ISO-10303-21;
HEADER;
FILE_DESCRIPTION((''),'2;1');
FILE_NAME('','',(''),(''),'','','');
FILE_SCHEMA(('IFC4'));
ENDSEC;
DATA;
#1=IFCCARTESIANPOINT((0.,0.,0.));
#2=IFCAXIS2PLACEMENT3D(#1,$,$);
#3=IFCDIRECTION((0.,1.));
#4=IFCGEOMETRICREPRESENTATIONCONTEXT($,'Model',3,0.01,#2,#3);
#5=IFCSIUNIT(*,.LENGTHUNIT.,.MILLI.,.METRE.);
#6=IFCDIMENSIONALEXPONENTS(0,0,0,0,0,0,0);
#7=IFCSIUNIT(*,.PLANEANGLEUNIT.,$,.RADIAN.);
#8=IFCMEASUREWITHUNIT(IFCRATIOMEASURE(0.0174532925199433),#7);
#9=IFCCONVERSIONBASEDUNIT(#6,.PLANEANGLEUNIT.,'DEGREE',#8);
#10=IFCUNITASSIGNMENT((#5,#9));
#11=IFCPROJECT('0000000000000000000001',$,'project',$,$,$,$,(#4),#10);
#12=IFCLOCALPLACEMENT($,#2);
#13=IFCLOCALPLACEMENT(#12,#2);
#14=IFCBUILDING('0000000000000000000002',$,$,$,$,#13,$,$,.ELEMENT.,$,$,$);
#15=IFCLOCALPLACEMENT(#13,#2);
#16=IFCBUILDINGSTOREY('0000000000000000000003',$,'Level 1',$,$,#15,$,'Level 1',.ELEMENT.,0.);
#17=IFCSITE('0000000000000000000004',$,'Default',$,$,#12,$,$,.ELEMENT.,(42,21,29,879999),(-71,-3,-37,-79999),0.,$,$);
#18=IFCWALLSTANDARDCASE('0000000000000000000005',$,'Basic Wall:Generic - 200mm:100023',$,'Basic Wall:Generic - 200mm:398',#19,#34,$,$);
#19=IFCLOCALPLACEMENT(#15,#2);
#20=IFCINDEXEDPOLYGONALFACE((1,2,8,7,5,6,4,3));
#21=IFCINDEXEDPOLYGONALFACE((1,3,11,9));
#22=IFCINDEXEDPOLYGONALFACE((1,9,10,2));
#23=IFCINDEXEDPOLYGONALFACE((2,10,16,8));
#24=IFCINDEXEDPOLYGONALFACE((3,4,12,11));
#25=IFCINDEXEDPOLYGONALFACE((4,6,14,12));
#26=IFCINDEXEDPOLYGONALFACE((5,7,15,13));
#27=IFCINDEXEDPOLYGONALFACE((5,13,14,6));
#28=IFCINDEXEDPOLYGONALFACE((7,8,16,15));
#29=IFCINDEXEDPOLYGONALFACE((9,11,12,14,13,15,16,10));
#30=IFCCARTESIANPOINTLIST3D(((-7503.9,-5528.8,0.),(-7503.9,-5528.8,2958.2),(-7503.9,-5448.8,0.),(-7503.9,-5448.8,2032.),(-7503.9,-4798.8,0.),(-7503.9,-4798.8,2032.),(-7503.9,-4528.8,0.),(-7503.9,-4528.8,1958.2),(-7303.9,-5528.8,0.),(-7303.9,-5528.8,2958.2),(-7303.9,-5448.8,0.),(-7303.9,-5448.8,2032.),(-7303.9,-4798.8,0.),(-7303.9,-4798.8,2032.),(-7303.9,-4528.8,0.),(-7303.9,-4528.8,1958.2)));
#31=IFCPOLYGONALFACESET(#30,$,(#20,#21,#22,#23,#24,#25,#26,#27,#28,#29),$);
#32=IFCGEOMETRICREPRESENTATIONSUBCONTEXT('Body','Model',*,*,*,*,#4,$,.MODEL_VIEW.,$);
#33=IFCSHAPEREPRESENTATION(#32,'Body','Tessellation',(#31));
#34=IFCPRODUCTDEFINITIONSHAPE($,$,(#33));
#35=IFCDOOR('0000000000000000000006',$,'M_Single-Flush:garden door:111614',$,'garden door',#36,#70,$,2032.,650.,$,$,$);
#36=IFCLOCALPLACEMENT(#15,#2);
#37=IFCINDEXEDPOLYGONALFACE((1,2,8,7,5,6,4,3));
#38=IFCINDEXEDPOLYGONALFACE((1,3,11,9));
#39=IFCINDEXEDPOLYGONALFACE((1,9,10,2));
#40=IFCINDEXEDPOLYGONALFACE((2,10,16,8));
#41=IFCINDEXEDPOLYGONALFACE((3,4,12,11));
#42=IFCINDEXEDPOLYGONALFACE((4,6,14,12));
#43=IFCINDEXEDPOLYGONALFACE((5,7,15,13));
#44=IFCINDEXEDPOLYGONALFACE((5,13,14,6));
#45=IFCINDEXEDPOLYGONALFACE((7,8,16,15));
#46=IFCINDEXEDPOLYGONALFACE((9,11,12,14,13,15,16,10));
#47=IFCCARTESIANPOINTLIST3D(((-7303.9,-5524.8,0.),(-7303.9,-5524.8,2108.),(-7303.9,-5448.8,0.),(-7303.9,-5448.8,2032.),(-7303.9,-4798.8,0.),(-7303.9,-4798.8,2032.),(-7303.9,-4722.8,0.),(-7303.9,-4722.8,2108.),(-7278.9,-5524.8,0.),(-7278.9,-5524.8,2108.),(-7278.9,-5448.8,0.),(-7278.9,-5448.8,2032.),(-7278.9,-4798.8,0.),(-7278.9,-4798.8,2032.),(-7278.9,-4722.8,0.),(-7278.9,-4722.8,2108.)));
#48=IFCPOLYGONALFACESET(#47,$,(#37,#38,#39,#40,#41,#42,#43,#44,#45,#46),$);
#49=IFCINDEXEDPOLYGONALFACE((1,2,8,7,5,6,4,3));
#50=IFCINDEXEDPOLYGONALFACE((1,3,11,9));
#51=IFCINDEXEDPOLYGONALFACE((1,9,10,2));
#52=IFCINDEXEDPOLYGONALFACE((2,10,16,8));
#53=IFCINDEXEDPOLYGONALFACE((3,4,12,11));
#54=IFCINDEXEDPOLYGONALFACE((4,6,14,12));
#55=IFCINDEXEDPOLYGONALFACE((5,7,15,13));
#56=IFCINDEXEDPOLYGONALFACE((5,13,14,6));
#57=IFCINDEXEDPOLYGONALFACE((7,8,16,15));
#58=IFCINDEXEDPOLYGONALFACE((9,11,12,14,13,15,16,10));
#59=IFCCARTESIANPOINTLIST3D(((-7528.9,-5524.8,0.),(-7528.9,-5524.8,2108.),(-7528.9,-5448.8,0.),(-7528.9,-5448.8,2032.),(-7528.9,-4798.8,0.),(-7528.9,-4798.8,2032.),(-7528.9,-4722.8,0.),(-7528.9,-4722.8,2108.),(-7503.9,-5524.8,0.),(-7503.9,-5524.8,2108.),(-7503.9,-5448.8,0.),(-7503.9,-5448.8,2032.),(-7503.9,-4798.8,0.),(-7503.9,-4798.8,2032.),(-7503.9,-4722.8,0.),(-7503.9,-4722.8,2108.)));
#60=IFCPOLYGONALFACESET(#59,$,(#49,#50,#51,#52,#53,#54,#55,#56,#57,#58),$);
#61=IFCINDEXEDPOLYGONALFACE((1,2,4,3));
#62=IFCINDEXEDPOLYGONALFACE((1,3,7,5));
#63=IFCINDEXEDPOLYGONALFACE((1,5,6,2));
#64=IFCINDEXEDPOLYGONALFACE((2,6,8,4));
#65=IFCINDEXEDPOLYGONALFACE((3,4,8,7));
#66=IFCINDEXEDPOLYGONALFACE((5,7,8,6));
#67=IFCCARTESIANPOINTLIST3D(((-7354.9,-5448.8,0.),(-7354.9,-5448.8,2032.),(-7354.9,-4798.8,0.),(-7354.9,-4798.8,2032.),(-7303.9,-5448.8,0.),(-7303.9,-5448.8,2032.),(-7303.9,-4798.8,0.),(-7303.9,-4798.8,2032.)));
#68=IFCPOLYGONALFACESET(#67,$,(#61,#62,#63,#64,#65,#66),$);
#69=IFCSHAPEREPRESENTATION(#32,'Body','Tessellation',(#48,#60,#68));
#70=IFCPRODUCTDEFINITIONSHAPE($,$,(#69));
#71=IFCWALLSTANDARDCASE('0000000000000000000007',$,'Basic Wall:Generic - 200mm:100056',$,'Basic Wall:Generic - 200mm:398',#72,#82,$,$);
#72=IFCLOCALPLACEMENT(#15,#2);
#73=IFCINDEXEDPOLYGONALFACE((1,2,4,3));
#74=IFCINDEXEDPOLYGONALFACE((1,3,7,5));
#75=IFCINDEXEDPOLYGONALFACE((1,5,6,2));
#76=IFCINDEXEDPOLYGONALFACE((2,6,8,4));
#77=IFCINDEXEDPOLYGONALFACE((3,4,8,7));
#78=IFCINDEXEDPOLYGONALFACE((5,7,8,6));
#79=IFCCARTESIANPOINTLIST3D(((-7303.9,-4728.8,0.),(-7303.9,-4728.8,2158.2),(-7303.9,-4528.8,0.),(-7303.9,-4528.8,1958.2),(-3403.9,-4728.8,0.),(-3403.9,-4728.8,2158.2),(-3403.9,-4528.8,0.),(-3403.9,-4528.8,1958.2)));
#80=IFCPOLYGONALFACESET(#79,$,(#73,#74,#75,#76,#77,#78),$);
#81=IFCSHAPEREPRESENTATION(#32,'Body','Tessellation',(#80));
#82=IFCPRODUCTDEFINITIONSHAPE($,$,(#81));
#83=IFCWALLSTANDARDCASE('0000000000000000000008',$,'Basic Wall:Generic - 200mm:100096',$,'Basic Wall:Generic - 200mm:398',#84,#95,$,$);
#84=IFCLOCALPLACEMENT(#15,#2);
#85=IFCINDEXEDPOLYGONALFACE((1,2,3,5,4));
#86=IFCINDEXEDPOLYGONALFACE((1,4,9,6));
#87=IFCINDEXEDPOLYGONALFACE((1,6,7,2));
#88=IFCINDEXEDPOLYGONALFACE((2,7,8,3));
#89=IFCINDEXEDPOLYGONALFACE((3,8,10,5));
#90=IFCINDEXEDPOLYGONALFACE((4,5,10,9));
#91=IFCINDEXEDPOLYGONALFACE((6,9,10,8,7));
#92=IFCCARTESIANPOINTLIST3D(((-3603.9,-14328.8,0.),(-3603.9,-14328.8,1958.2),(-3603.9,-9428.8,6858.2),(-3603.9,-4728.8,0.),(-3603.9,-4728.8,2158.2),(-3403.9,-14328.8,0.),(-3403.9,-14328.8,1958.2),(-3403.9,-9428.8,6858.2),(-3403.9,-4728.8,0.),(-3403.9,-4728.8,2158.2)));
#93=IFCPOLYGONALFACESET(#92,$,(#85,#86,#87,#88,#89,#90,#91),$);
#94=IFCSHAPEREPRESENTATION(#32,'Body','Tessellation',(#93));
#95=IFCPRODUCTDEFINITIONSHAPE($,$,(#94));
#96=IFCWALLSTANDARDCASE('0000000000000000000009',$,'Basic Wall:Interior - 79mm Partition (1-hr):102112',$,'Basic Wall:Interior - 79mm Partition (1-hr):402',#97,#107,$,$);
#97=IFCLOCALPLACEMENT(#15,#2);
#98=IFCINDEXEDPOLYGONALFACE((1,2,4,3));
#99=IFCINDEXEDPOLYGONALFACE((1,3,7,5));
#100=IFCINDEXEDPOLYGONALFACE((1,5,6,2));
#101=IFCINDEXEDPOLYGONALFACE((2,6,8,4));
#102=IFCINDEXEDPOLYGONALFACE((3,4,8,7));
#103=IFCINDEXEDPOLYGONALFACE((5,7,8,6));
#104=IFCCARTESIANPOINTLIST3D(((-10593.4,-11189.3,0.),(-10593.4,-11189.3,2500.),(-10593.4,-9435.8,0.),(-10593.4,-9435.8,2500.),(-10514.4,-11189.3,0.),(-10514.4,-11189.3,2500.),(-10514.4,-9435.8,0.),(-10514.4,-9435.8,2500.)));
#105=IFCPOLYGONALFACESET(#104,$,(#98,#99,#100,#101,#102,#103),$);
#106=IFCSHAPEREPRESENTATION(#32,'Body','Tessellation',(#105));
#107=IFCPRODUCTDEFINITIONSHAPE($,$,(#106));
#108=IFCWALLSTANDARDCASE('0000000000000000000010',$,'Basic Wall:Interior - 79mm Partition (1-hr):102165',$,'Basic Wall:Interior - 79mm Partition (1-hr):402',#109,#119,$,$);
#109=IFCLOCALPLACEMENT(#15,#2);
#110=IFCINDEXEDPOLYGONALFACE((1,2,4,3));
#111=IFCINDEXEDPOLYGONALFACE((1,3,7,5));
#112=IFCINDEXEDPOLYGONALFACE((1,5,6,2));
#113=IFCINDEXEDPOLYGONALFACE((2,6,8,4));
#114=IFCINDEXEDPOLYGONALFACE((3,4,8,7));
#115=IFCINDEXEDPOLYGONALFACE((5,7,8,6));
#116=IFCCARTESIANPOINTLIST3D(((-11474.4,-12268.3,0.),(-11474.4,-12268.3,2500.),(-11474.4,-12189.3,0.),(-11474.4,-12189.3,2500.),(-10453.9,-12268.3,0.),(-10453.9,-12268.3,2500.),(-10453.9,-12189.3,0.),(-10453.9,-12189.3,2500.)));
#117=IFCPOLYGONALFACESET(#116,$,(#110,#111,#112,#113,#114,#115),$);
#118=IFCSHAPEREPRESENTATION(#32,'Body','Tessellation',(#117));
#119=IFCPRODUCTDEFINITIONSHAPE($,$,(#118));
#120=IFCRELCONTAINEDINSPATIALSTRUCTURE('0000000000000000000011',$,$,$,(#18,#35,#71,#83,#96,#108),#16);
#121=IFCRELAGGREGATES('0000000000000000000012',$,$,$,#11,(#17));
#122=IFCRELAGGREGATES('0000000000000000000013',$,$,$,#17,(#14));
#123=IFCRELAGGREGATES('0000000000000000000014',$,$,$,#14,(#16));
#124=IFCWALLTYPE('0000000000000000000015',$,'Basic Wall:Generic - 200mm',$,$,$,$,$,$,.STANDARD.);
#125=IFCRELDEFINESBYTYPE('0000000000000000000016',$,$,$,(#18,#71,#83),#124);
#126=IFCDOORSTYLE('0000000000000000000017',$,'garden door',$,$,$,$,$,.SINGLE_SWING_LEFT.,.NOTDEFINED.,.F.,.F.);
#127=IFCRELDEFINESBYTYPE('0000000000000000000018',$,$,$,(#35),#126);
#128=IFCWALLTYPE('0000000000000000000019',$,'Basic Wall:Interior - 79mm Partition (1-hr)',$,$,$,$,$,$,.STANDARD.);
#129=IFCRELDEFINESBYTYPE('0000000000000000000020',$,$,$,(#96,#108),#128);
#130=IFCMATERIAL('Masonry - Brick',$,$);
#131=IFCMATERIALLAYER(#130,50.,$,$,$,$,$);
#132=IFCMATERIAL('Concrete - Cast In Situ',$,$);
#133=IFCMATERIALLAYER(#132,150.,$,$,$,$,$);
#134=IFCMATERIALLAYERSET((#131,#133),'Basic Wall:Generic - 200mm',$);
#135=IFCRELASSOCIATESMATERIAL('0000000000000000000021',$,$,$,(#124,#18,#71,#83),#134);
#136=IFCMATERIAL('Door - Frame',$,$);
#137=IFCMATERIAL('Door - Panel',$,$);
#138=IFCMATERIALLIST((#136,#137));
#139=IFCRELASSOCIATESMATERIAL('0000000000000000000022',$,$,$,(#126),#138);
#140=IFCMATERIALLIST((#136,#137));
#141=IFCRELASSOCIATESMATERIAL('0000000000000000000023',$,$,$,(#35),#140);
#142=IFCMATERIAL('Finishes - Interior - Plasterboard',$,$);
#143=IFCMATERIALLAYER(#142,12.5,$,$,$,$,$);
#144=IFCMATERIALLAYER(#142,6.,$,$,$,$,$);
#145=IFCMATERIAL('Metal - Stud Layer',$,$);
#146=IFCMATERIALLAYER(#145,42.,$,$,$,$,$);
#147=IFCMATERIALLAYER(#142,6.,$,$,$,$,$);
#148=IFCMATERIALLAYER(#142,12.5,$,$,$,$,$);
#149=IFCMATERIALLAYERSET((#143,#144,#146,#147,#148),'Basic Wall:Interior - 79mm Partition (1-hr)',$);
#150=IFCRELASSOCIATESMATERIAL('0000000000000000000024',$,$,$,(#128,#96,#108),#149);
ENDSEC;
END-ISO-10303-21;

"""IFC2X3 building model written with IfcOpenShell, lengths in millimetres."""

from ifc_helpers import new_model, entity, si_unit, converted_unit, direction, frame, frame_2d, origin, place, context, subcontext, project, spatial, polyline, rectangle, outline, extrude, clip, bounded_halfspace, source, transform, mapped, material, material_list, layer, layer_set, layer_usage, type_object, type_shapes, element, fill, save


model = new_model("IFC2X3")

# Units and contexts
model_context = context("Model", 3, precision=0.01, world=origin(), true_north=direction((0.0, 1.0)))
body_context = subcontext(model_context, "Body", "Model", "MODEL_VIEW")
ifc_project = project(units=[si_unit("LENGTHUNIT", "METRE", prefix="MILLI"), converted_unit("PLANEANGLEUNIT", "DEGREE", entity("IfcRatioMeasure", 0.0174532925199433), si_unit("PLANEANGLEUNIT", "RADIAN"), dimensions=[0, 0, 0, 0, 0, 0, 0])], contexts=[model_context])

# Site, building, storey
site_placement = place(None, origin())
site = spatial("IfcSite", under=ifc_project, at=site_placement, Name="Default", CompositionType="ELEMENT", RefLatitude=(42, 21, 29, 879999), RefLongitude=(-71, -3, -37, -79999), RefElevation=0.0)
building_placement = place(site_placement, origin())
building = spatial("IfcBuilding", under=site, at=building_placement, CompositionType="ELEMENT")
storey_placement = place(building_placement, origin())
storey = spatial("IfcBuildingStorey", under=building, at=storey_placement, Name="Level 1", LongName="Level 1", CompositionType="ELEMENT", Elevation=0.0)

# Wall, opening, door
ifc_material_1 = material(Name="Masonry - Brick")
ifc_layer_1 = layer(ifc_material_1, 50.0)
ifc_material_2 = material(Name="Concrete - Cast In Situ")
ifc_layer_2 = layer(ifc_material_2, 150.0)
ifc_layer_set_1 = layer_set([ifc_layer_1, ifc_layer_2], Name="Basic Wall:Generic - 200mm")
ifc_layer_usage_1 = layer_usage(ifc_layer_set_1, "AXIS2", "NEGATIVE", 100.0)
wall_type_1 = type_object("IfcWallType", Name="Basic Wall:Generic - 200mm", PredefinedType="STANDARD", material=ifc_layer_set_1)
wall_1_placement = place(storey_placement, frame((-7403.9, -5528.8, 0.0), z_axis=(0.0, 0.0, 1.0), x_axis=(0.0, 1.0, 0.0)))
wall_1 = element("IfcWallStandardCase", 1, at=wall_1_placement, inside=storey, type_object=wall_type_1, material=ifc_layer_usage_1, Name="Basic Wall:Generic - 200mm:100023", ObjectType="Basic Wall:Generic - 200mm:398", context=body_context, shape_type="Clipping", body=[
    clip(extrude(rectangle(XDim=1000.0, YDim=200.0, at=frame_2d((500.0, 0.0), x_axis=(-1.0, 0.0))), origin(), (0.0, 0.0, 1.0), 2958.2), bounded_halfspace(frame((0.0, 100.0, 2958.2), z_axis=(-0.707107, 0.0, -0.707107), x_axis=(0.0, 1.0, 0.0)), True, frame((0.0, 100.0, 2958.2)), polyline([(0.0, 0.0), (0.0, -200.0), (800.0, -200.0), (1000.0, -200.0), (1000.0, 0.0), (400.0, 0.0), (0.0, 0.0)]))),
])
opening_1_placement = place(wall_1_placement, frame((730.0, 100.0, 0.0)))
opening_1 = element("IfcOpeningElement", 2, at=opening_1_placement, cuts=wall_1, ObjectType="Opening", context=body_context, shape_type="SweptSolid", body=[
    extrude(rectangle(XDim=650.0, YDim=2032.0, at=frame_2d((1016.0, 325.0), x_axis=(0.0, -1.0))), frame((0.0, 0.0, 0.0), z_axis=(0.0, -1.0, 0.0), x_axis=(0.0, 0.0, 1.0)), (0.0, 0.0, 1.0), 200.0),
])
ifc_material_3 = material(Name="Door - Frame")
ifc_material_4 = material(Name="Door - Panel")
ifc_material_list_1 = material_list([ifc_material_3, ifc_material_4])
ifc_material_list_2 = material_list([ifc_material_3, ifc_material_4])
door_style_1 = type_object("IfcDoorStyle", Name="garden door", ConstructionType="NOTDEFINED", OperationType="SINGLE_SWING_LEFT", ParameterTakesPrecedence=False, Sizeable=False, material=ifc_material_list_2)
shared_shape_1 = source(origin(), body_context, "Body", "SweptSolid", [
    extrude(outline(polyline([(-401.0, -1073.0), (401.0, -1073.0), (401.0, 1035.0), (325.0, 1035.0), (325.0, -997.0), (-325.0, -997.0), (-325.0, 1035.0), (-401.0, 1035.0), (-401.0, -1073.0)])), frame((325.0, 225.0, 1035.0), z_axis=(0.0, -1.0, 0.0), x_axis=(-1.0, 0.0, 0.0)), (0.0, 0.0, 1.0), 25.0),
    extrude(outline(polyline([(-1073.0, -401.0), (1035.0, -401.0), (1035.0, -325.0), (-997.0, -325.0), (-997.0, 325.0), (1035.0, 325.0), (1035.0, 401.0), (-1073.0, 401.0), (-1073.0, -401.0)])), frame((325.0, 0.0, 1035.0), z_axis=(0.0, -1.0, 0.0), x_axis=(0.0, 0.0, -1.0)), (0.0, 0.0, 1.0), 25.0),
    extrude(rectangle(XDim=650.0, YDim=51.0, at=frame_2d((0.0, 0.0), x_axis=(1.0, 0.0))), frame((325.0, 174.5, 0.0)), (0.0, 0.0, 1.0), 2032.0),
])
type_shapes(door_style_1, [shared_shape_1])
door_1_placement = place(opening_1_placement, frame((0.0, 0.0, 0.0), z_axis=(0.0, 0.0, 1.0), x_axis=(-1.0, 0.0, 0.0)))
door_1 = element("IfcDoor", 3, at=door_1_placement, inside=storey, type_object=door_style_1, material=ifc_material_list_1, Name="M_Single-Flush:garden door:111614", ObjectType="garden door", OverallHeight=2032.0, OverallWidth=650.0, context=body_context, shape_type="MappedRepresentation", body=[
    mapped(shared_shape_1, transform((0.0, 0.0, 0.0), scale=1.0)),
])
fill(opening_1, door_1)

# Walls
ifc_layer_usage_2 = layer_usage(ifc_layer_set_1, "AXIS2", "NEGATIVE", 100.0)
wall_2_placement = place(storey_placement, frame((-7303.9, -4628.8, 0.0)))
element("IfcWallStandardCase", 4, at=wall_2_placement, inside=storey, type_object=wall_type_1, material=ifc_layer_usage_2, Name="Basic Wall:Generic - 200mm:100056", ObjectType="Basic Wall:Generic - 200mm:398", context=body_context, shape_type="Clipping", body=[
    clip(extrude(rectangle(XDim=3900.0, YDim=200.0, at=frame_2d((1950.0, 0.0), x_axis=(-1.0, 0.0))), origin(), (0.0, 0.0, 1.0), 2158.2), bounded_halfspace(frame((0.0, -100.0, 2158.2), z_axis=(0.0, -0.707107, -0.707107), x_axis=(-1.0, 0.0, 0.0)), True, frame((0.0, -100.0, 2158.2)), polyline([(0.0, 0.0), (3700.0, 0.0), (3900.0, 0.0), (3900.0, 200.0), (0.0, 200.0), (0.0, 0.0)]))),
])
ifc_layer_usage_3 = layer_usage(ifc_layer_set_1, "AXIS2", "NEGATIVE", 100.0)
wall_3_placement = place(storey_placement, frame((-3503.9, -4728.8, 0.0), z_axis=(0.0, 0.0, 1.0), x_axis=(0.0, -1.0, 0.0)))
element("IfcWallStandardCase", 5, at=wall_3_placement, inside=storey, type_object=wall_type_1, material=ifc_layer_usage_3, Name="Basic Wall:Generic - 200mm:100096", ObjectType="Basic Wall:Generic - 200mm:398", context=body_context, shape_type="Clipping", body=[
    clip(clip(extrude(rectangle(XDim=9600.0, YDim=200.0, at=frame_2d((4800.0, 0.0), x_axis=(-1.0, 0.0))), origin(), (0.0, 0.0, 1.0), 6858.2), bounded_halfspace(frame((4700.0, -100.0, 6858.2), z_axis=(-0.707107, 0.0, -0.707107), x_axis=(0.0, -1.0, 0.0)), True, frame((4700.0, -100.0, 6858.2)), polyline([(0.0, 0.0), (4700.0, 0.0), (4900.0, 0.0), (4900.0, 200.0), (0.0, 200.0), (0.0, 0.0)]))), bounded_halfspace(frame((0.0, -100.0, 2158.2), z_axis=(0.707107, 0.0, -0.707107), x_axis=(0.0, -1.0, 0.0)), True, frame((0.0, -100.0, 2158.2)), polyline([(0.0, 0.0), (4700.0, 0.0), (4700.0, 200.0), (0.0, 200.0), (0.0, 0.0)]))),
])

# Walls
ifc_material_5 = material(Name="Finishes - Interior - Plasterboard")
ifc_layer_3 = layer(ifc_material_5, 12.5)
ifc_layer_4 = layer(ifc_material_5, 6.0)
ifc_material_6 = material(Name="Metal - Stud Layer")
ifc_layer_5 = layer(ifc_material_6, 42.0)
ifc_layer_6 = layer(ifc_material_5, 6.0)
ifc_layer_7 = layer(ifc_material_5, 12.5)
ifc_layer_set_2 = layer_set([ifc_layer_3, ifc_layer_4, ifc_layer_5, ifc_layer_6, ifc_layer_7], Name="Basic Wall:Interior - 79mm Partition (1-hr)")
ifc_layer_usage_4 = layer_usage(ifc_layer_set_2, "AXIS2", "NEGATIVE", 39.5)
wall_type_2 = type_object("IfcWallType", Name="Basic Wall:Interior - 79mm Partition (1-hr)", PredefinedType="STANDARD", material=ifc_layer_set_2)
wall_4_placement = place(storey_placement, frame((-10553.9, -11189.3, 0.0), z_axis=(0.0, 0.0, 1.0), x_axis=(0.0, 1.0, 0.0)))
element("IfcWallStandardCase", 6, at=wall_4_placement, inside=storey, type_object=wall_type_2, material=ifc_layer_usage_4, Name="Basic Wall:Interior - 79mm Partition (1-hr):102112", ObjectType="Basic Wall:Interior - 79mm Partition (1-hr):402", context=body_context, shape_type="SweptSolid", body=[
    extrude(rectangle(XDim=1753.5, YDim=79.0, at=frame_2d((876.8, 0.0), x_axis=(-1.0, 0.0))), origin(), (0.0, 0.0, 1.0), 2500.0),
])
ifc_layer_usage_5 = layer_usage(ifc_layer_set_2, "AXIS2", "NEGATIVE", 39.5)
wall_5_placement = place(storey_placement, frame((-11474.4, -12228.8, 0.0)))
element("IfcWallStandardCase", 7, at=wall_5_placement, inside=storey, type_object=wall_type_2, material=ifc_layer_usage_5, Name="Basic Wall:Interior - 79mm Partition (1-hr):102165", ObjectType="Basic Wall:Interior - 79mm Partition (1-hr):402", context=body_context, shape_type="SweptSolid", body=[
    extrude(rectangle(XDim=1020.5, YDim=79.0, at=frame_2d((510.3, 0.0), x_axis=(-1.0, 0.0))), origin(), (0.0, 0.0, 1.0), 2500.0),
])

save(model, "model.ifc")
